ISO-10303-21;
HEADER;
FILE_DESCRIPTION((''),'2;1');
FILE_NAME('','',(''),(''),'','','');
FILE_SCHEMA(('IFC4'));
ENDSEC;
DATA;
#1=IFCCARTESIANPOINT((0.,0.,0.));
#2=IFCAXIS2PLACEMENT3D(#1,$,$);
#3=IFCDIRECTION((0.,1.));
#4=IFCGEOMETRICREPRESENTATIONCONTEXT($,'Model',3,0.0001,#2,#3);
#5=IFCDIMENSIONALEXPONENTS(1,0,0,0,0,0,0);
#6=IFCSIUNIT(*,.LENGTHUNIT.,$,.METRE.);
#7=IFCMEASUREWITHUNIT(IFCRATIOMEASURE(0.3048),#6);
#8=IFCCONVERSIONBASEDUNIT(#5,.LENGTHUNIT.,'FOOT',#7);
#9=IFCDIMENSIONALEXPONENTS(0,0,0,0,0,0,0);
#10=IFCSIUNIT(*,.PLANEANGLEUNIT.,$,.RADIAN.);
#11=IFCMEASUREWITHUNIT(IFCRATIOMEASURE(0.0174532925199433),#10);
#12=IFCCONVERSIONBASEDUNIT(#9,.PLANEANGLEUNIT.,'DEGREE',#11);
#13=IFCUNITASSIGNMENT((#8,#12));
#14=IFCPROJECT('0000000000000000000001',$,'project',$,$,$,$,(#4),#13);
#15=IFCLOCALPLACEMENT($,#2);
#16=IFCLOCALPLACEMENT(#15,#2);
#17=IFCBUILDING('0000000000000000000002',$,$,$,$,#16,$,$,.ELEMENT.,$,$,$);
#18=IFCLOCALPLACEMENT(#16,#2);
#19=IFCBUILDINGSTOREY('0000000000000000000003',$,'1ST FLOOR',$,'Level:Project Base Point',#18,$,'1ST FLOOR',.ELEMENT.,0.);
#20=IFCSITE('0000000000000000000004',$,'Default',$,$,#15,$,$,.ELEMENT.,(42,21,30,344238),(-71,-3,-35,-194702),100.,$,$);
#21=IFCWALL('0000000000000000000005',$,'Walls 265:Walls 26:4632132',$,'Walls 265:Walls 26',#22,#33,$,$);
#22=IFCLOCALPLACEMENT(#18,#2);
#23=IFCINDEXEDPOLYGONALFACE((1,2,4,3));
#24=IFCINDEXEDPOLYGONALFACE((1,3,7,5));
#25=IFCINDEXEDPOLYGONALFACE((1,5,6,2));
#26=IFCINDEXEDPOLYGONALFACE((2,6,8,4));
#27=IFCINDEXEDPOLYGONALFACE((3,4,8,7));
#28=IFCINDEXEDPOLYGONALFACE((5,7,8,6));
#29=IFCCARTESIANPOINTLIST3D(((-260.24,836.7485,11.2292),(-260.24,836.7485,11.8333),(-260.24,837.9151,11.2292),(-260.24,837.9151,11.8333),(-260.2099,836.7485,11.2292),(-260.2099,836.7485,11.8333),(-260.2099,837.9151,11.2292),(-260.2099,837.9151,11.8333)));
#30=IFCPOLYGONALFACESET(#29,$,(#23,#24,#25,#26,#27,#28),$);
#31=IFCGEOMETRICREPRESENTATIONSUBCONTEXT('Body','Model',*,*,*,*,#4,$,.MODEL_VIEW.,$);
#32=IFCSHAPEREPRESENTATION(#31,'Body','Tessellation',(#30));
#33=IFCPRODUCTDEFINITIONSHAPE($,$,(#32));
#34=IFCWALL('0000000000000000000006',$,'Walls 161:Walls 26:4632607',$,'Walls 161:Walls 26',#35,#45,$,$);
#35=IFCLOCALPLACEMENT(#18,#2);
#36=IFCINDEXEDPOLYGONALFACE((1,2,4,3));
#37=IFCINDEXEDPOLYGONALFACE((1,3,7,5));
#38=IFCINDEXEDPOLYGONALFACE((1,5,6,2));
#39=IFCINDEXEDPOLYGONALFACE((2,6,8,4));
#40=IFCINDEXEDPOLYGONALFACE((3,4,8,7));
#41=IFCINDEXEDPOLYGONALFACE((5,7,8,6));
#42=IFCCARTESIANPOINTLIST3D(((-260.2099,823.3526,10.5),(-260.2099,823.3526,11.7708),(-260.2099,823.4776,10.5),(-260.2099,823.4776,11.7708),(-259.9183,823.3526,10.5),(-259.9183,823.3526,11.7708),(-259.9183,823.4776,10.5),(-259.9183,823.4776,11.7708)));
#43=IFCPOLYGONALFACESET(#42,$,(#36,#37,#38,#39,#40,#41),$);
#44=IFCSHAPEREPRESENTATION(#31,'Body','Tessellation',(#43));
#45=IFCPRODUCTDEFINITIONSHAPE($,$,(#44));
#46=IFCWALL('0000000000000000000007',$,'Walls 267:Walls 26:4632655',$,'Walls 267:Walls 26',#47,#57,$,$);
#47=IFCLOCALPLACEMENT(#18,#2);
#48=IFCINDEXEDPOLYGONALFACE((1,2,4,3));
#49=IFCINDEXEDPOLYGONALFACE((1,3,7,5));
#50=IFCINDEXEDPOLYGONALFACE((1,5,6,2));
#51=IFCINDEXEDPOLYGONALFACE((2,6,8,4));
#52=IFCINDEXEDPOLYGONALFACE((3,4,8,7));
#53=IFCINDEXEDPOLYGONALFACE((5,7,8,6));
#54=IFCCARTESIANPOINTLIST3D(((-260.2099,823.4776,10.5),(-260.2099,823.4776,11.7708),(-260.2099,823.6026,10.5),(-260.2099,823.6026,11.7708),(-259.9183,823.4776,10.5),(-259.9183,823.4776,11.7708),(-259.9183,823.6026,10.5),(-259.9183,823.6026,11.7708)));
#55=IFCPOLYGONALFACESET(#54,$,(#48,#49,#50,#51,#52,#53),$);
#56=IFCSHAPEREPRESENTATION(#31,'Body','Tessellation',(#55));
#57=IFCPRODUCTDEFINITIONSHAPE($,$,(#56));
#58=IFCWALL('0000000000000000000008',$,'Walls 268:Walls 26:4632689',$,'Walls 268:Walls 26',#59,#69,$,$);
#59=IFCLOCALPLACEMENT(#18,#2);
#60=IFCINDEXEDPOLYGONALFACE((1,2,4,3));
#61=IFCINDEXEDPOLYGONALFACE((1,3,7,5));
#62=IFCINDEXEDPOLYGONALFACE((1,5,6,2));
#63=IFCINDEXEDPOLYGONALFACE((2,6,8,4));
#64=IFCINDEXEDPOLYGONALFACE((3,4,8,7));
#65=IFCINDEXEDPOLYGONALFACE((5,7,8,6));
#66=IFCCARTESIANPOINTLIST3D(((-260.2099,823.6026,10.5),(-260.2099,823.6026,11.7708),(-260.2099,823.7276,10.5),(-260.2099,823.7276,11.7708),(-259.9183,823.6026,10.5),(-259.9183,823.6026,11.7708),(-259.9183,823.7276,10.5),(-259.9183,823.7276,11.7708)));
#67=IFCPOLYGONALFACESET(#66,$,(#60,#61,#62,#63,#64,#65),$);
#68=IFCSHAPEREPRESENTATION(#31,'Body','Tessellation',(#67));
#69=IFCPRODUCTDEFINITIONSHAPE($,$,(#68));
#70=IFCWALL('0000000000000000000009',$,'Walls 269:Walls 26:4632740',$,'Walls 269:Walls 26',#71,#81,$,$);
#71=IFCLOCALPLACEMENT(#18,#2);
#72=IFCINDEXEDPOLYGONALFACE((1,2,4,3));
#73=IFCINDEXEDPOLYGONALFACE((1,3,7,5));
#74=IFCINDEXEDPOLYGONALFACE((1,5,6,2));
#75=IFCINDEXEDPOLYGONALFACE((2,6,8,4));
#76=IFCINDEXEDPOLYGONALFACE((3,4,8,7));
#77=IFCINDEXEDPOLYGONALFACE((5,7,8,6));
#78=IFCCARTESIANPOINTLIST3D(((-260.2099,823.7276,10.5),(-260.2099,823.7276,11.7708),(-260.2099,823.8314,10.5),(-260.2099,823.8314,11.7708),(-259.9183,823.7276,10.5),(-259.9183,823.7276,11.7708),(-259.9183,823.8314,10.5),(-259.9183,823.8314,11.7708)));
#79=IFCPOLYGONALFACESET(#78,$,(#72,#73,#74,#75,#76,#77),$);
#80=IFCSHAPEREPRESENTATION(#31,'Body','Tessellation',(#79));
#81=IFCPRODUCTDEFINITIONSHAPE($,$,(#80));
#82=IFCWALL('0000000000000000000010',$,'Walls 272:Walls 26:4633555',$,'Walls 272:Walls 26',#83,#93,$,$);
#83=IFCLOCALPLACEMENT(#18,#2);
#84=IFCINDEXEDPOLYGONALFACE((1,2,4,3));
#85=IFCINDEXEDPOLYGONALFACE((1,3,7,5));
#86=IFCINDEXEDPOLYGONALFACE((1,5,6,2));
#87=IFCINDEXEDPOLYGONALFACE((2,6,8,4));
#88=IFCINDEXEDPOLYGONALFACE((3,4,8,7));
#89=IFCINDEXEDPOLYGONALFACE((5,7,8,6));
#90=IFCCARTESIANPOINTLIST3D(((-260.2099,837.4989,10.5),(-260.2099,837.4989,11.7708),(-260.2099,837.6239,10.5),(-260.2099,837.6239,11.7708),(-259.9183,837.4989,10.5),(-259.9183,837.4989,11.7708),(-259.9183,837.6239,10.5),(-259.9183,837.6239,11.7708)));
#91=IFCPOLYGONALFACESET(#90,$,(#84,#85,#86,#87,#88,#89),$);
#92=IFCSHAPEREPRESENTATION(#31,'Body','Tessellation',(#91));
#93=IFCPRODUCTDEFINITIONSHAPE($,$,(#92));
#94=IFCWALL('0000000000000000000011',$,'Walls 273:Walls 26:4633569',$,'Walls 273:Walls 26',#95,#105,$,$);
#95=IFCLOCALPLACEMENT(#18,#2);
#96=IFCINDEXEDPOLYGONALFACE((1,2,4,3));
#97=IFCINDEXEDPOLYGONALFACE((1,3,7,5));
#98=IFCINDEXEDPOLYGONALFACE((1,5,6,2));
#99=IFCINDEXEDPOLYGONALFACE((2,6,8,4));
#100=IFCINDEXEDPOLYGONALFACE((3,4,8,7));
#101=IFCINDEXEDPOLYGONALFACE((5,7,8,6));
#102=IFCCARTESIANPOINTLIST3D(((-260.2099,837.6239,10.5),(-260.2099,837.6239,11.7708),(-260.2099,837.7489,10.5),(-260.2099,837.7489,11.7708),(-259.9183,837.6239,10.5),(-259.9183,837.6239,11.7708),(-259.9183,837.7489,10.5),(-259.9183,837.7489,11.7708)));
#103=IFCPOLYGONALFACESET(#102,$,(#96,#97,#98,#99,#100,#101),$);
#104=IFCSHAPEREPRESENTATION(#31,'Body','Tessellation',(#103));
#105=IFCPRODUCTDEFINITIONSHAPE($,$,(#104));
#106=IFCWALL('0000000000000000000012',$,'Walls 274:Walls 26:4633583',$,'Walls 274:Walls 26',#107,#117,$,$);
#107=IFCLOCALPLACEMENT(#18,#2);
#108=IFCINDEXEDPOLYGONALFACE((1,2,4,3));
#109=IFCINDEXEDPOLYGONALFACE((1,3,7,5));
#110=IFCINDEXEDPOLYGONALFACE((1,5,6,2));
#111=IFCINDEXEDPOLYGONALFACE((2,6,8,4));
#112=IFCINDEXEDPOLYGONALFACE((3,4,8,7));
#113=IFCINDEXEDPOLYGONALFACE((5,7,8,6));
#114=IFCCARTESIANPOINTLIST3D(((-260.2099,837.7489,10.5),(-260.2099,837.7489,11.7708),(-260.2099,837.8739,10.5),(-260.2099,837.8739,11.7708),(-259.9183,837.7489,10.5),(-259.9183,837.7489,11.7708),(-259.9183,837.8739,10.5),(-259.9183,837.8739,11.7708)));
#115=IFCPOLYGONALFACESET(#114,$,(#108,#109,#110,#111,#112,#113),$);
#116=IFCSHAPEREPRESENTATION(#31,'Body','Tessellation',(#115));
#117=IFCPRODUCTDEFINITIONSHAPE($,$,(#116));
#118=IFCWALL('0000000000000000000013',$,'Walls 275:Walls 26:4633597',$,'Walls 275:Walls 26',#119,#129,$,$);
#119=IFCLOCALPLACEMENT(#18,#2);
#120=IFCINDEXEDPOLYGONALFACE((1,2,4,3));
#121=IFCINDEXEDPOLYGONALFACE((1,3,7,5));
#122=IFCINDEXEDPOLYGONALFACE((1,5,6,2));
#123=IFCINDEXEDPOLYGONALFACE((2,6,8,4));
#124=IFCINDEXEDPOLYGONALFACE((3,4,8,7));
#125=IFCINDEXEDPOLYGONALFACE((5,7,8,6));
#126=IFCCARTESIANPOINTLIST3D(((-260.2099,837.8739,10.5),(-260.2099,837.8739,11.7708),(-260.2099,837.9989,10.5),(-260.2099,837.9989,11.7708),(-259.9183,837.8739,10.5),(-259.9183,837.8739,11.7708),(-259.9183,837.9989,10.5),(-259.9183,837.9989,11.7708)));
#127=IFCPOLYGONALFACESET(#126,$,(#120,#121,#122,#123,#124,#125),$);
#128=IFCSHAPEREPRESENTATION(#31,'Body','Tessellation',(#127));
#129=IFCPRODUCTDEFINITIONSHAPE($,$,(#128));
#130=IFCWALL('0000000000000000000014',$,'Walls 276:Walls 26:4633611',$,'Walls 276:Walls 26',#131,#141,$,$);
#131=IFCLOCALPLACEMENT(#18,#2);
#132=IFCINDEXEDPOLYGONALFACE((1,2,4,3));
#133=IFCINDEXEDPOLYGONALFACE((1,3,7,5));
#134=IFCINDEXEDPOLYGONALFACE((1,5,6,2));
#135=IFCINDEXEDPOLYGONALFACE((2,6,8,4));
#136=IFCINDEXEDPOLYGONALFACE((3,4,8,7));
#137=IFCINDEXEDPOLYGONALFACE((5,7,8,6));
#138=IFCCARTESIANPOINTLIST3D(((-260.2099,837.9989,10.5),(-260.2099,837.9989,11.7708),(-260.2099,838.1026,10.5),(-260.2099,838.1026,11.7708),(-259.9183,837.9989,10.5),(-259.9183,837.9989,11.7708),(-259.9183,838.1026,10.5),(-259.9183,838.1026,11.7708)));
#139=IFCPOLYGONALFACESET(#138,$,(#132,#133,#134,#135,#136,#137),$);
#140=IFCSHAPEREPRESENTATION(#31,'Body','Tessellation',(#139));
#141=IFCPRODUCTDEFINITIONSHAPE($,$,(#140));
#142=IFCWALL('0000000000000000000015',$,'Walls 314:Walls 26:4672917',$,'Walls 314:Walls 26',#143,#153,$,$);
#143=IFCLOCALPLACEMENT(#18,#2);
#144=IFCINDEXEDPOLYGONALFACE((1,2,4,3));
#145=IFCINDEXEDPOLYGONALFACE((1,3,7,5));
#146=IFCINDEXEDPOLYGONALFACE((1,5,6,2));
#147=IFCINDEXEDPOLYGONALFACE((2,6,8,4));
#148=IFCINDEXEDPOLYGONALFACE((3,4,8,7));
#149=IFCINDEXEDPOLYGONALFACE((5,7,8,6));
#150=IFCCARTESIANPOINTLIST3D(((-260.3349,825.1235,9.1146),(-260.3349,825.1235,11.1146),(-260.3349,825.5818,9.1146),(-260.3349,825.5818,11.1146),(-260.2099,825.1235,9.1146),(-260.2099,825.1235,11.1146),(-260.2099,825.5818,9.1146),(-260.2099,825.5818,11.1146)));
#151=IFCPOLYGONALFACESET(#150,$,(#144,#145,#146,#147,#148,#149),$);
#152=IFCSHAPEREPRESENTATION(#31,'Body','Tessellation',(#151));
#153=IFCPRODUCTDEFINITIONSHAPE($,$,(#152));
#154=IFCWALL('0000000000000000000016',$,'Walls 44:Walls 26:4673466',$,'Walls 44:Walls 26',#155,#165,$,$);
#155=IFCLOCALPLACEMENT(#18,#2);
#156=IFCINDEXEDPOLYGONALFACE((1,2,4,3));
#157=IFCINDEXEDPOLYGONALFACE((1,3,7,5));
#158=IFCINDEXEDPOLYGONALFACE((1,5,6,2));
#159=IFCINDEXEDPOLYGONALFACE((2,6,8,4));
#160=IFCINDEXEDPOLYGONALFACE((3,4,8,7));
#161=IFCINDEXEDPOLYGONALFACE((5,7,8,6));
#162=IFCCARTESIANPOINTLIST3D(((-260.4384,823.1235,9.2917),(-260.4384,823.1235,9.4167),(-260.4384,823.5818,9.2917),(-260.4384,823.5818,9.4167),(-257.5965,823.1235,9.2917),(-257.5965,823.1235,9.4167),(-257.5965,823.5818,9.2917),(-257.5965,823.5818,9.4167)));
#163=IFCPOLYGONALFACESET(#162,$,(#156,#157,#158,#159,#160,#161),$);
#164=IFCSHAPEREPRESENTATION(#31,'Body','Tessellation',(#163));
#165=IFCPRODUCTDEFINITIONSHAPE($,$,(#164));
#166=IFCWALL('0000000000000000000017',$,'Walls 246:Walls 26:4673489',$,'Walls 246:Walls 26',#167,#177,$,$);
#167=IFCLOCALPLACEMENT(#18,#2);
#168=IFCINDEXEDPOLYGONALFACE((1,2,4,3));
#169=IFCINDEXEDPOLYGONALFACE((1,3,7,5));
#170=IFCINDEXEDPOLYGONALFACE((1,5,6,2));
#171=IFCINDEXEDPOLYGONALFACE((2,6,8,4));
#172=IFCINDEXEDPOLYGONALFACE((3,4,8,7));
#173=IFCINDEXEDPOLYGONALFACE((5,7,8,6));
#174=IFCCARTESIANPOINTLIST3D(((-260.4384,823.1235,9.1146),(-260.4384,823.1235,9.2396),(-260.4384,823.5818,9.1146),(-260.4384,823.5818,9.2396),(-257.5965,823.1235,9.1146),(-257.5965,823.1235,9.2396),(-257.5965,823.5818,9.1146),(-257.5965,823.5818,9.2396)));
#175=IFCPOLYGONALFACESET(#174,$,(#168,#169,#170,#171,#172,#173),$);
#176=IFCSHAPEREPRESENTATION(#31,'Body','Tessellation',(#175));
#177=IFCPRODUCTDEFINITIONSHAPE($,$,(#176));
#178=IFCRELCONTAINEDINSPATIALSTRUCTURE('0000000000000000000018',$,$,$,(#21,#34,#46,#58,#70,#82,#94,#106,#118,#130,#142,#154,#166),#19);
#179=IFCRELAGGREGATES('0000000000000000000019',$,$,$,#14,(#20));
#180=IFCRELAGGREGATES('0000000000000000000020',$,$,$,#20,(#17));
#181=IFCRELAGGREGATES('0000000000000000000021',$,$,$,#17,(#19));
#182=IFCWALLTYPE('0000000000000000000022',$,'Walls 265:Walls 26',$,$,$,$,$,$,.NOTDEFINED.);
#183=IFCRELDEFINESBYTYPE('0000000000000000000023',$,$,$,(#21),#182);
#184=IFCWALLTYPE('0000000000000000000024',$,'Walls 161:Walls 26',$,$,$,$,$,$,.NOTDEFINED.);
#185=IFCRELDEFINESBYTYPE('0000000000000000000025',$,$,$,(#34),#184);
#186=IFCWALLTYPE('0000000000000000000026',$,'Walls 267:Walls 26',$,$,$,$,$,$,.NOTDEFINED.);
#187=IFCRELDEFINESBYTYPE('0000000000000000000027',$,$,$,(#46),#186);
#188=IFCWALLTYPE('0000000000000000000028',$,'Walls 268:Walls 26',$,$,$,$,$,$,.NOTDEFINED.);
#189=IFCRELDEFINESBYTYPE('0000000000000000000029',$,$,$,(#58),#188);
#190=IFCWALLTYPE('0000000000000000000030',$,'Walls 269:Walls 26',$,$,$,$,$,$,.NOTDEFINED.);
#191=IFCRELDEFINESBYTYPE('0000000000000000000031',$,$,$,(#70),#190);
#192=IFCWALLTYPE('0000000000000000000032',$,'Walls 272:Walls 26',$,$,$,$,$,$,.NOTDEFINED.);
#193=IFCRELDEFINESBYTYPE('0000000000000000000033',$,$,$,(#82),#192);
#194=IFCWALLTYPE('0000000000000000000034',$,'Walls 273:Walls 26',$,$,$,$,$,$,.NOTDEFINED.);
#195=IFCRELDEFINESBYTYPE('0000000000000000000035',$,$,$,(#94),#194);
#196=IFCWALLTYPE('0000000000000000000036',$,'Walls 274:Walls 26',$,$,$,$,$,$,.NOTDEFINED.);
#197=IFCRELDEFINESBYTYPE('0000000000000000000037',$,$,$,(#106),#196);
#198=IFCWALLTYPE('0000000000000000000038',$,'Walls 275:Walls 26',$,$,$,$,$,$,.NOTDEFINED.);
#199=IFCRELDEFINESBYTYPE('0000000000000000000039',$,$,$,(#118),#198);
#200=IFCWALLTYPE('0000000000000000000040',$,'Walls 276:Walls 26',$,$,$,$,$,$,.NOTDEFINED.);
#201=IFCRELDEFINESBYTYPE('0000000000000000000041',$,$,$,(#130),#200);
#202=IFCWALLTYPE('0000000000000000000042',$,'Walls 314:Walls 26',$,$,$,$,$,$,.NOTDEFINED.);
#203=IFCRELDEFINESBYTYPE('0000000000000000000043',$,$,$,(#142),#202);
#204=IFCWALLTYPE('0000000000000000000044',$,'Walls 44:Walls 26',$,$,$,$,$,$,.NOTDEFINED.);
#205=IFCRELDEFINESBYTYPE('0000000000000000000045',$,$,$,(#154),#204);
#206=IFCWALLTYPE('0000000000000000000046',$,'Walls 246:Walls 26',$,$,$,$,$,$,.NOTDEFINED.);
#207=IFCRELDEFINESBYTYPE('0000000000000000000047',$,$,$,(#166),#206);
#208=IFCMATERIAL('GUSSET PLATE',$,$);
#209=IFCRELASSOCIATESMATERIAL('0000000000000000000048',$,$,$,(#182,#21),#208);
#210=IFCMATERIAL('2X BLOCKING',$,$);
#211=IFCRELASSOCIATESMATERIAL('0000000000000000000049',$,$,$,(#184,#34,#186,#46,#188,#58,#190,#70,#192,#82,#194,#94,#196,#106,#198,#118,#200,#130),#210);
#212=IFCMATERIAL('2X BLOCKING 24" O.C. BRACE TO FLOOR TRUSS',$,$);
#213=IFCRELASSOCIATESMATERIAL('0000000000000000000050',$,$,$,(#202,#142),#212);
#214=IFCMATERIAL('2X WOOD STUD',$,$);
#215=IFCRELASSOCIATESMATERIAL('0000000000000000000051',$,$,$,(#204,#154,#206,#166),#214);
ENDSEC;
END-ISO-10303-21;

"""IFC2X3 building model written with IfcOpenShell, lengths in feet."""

from ifc_helpers import new_model, entity, si_unit, converted_unit, direction, frame, frame_2d, origin, place, context, subcontext, project, spatial, rectangle, extrude, material, type_object, element, save


model = new_model("IFC2X3")

# Units and contexts
model_context = context("Model", 3, precision=0.0001, world=origin(), true_north=direction((0.0, 1.0)))
body_context = subcontext(model_context, "Body", "Model", "MODEL_VIEW")
ifc_project = project(units=[converted_unit("LENGTHUNIT", "FOOT", entity("IfcRatioMeasure", 0.3048), si_unit("LENGTHUNIT", "METRE"), dimensions=[1, 0, 0, 0, 0, 0, 0]), converted_unit("PLANEANGLEUNIT", "DEGREE", entity("IfcRatioMeasure", 0.0174532925199433), si_unit("PLANEANGLEUNIT", "RADIAN"), dimensions=[0, 0, 0, 0, 0, 0, 0])], contexts=[model_context])

# Site, building, storey
site_placement = place(None, origin())
site = spatial("IfcSite", under=ifc_project, at=site_placement, Name="Default", CompositionType="ELEMENT", RefLatitude=(42, 21, 30, 344238), RefLongitude=(-71, -3, -35, -194702), RefElevation=100.0)
building_placement = place(site_placement, origin())
building = spatial("IfcBuilding", under=site, at=building_placement, CompositionType="ELEMENT")
storey_placement = place(building_placement, origin())
storey = spatial("IfcBuildingStorey", under=building, at=storey_placement, Name="1ST FLOOR", ObjectType="Level:Project Base Point", LongName="1ST FLOOR", CompositionType="ELEMENT", Elevation=0.0)

# Walls
ifc_material_1 = material(Name="GUSSET PLATE")
ifc_material_2 = material(Name="2X BLOCKING")
wall_type_1 = type_object("IfcWallType", Name="Walls 265:Walls 26", PredefinedType="NOTDEFINED", material=ifc_material_1)
wall_1_placement = place(storey_placement, frame((-260.24, 836.7485, 11.2292), z_axis=(0.0, 0.0, 1.0), x_axis=(0.0, 1.0, 0.0)))
element("IfcWall", 1, at=wall_1_placement, inside=storey, type_object=wall_type_1, material=ifc_material_1, Name="Walls 265:Walls 26:4632132", ObjectType="Walls 265:Walls 26", context=body_context, shape_type="SweptSolid", body=[
    extrude(rectangle(XDim=0.0301, YDim=1.1667, at=frame_2d((0.0, 0.0), x_axis=(1.0, 0.0))), frame((0.5833, -0.0151, 0.0), z_axis=(0.0, 0.0, 1.0), x_axis=(0.0, 1.0, 0.0)), (0.0, 0.0, 1.0), 0.6042),
])
wall_type_2 = type_object("IfcWallType", Name="Walls 161:Walls 26", PredefinedType="NOTDEFINED", material=ifc_material_2)
wall_2_placement = place(storey_placement, frame((-260.2099, 823.3526, 10.5)))
element("IfcWall", 2, at=wall_2_placement, inside=storey, type_object=wall_type_2, material=ifc_material_2, Name="Walls 161:Walls 26:4632607", ObjectType="Walls 161:Walls 26", context=body_context, shape_type="SweptSolid", body=[
    extrude(rectangle(XDim=0.2917, YDim=0.125, at=frame_2d((0.0, 0.0), x_axis=(1.0, 0.0))), frame((0.1458, 0.0625, 0.0), z_axis=(0.0, 0.0, 1.0), x_axis=(-1.0, 0.0, 0.0)), (0.0, 0.0, 1.0), 1.2708),
])
wall_type_3 = type_object("IfcWallType", Name="Walls 267:Walls 26", PredefinedType="NOTDEFINED", material=ifc_material_2)
wall_3_placement = place(storey_placement, frame((-260.2099, 823.4776, 10.5)))
element("IfcWall", 3, at=wall_3_placement, inside=storey, type_object=wall_type_3, material=ifc_material_2, Name="Walls 267:Walls 26:4632655", ObjectType="Walls 267:Walls 26", context=body_context, shape_type="SweptSolid", body=[
    extrude(rectangle(XDim=0.2917, YDim=0.125, at=frame_2d((0.0, 0.0), x_axis=(1.0, 0.0))), frame((0.1458, 0.0625, 0.0), z_axis=(0.0, 0.0, 1.0), x_axis=(-1.0, 0.0, 0.0)), (0.0, 0.0, 1.0), 1.2708),
])
wall_type_4 = type_object("IfcWallType", Name="Walls 268:Walls 26", PredefinedType="NOTDEFINED", material=ifc_material_2)
wall_4_placement = place(storey_placement, frame((-260.2099, 823.6026, 10.5)))
element("IfcWall", 4, at=wall_4_placement, inside=storey, type_object=wall_type_4, material=ifc_material_2, Name="Walls 268:Walls 26:4632689", ObjectType="Walls 268:Walls 26", context=body_context, shape_type="SweptSolid", body=[
    extrude(rectangle(XDim=0.2917, YDim=0.125, at=frame_2d((0.0, 0.0), x_axis=(1.0, 0.0))), frame((0.1458, 0.0625, 0.0), z_axis=(0.0, 0.0, 1.0), x_axis=(-1.0, 0.0, 0.0)), (0.0, 0.0, 1.0), 1.2708),
])
wall_type_5 = type_object("IfcWallType", Name="Walls 269:Walls 26", PredefinedType="NOTDEFINED", material=ifc_material_2)
wall_5_placement = place(storey_placement, frame((-260.2099, 823.7276, 10.5)))
element("IfcWall", 5, at=wall_5_placement, inside=storey, type_object=wall_type_5, material=ifc_material_2, Name="Walls 269:Walls 26:4632740", ObjectType="Walls 269:Walls 26", context=body_context, shape_type="SweptSolid", body=[
    extrude(rectangle(XDim=0.2917, YDim=0.1038, at=frame_2d((0.0, 0.0), x_axis=(1.0, 0.0))), frame((0.1458, 0.0519, 0.0), z_axis=(0.0, 0.0, 1.0), x_axis=(-1.0, 0.0, 0.0)), (0.0, 0.0, 1.0), 1.2708),
])
wall_type_6 = type_object("IfcWallType", Name="Walls 272:Walls 26", PredefinedType="NOTDEFINED", material=ifc_material_2)
wall_6_placement = place(storey_placement, frame((-260.2099, 837.4989, 10.5)))
element("IfcWall", 6, at=wall_6_placement, inside=storey, type_object=wall_type_6, material=ifc_material_2, Name="Walls 272:Walls 26:4633555", ObjectType="Walls 272:Walls 26", context=body_context, shape_type="SweptSolid", body=[
    extrude(rectangle(XDim=0.2917, YDim=0.125, at=frame_2d((0.0, 0.0), x_axis=(1.0, 0.0))), frame((0.1458, 0.0625, 0.0), z_axis=(0.0, 0.0, 1.0), x_axis=(-1.0, 0.0, 0.0)), (0.0, 0.0, 1.0), 1.2708),
])
wall_type_7 = type_object("IfcWallType", Name="Walls 273:Walls 26", PredefinedType="NOTDEFINED", material=ifc_material_2)
wall_7_placement = place(storey_placement, frame((-260.2099, 837.6239, 10.5)))
element("IfcWall", 7, at=wall_7_placement, inside=storey, type_object=wall_type_7, material=ifc_material_2, Name="Walls 273:Walls 26:4633569", ObjectType="Walls 273:Walls 26", context=body_context, shape_type="SweptSolid", body=[
    extrude(rectangle(XDim=0.2917, YDim=0.125, at=frame_2d((0.0, 0.0), x_axis=(1.0, 0.0))), frame((0.1458, 0.0625, 0.0), z_axis=(0.0, 0.0, 1.0), x_axis=(-1.0, 0.0, 0.0)), (0.0, 0.0, 1.0), 1.2708),
])
wall_type_8 = type_object("IfcWallType", Name="Walls 274:Walls 26", PredefinedType="NOTDEFINED", material=ifc_material_2)
wall_8_placement = place(storey_placement, frame((-260.2099, 837.7489, 10.5)))
element("IfcWall", 8, at=wall_8_placement, inside=storey, type_object=wall_type_8, material=ifc_material_2, Name="Walls 274:Walls 26:4633583", ObjectType="Walls 274:Walls 26", context=body_context, shape_type="SweptSolid", body=[
    extrude(rectangle(XDim=0.2917, YDim=0.125, at=frame_2d((0.0, 0.0), x_axis=(1.0, 0.0))), frame((0.1458, 0.0625, 0.0), z_axis=(0.0, 0.0, 1.0), x_axis=(-1.0, 0.0, 0.0)), (0.0, 0.0, 1.0), 1.2708),
])
wall_type_9 = type_object("IfcWallType", Name="Walls 275:Walls 26", PredefinedType="NOTDEFINED", material=ifc_material_2)
wall_9_placement = place(storey_placement, frame((-260.2099, 837.8739, 10.5)))
element("IfcWall", 9, at=wall_9_placement, inside=storey, type_object=wall_type_9, material=ifc_material_2, Name="Walls 275:Walls 26:4633597", ObjectType="Walls 275:Walls 26", context=body_context, shape_type="SweptSolid", body=[
    extrude(rectangle(XDim=0.2917, YDim=0.125, at=frame_2d((0.0, 0.0), x_axis=(1.0, 0.0))), frame((0.1458, 0.0625, 0.0), z_axis=(0.0, 0.0, 1.0), x_axis=(-1.0, 0.0, 0.0)), (0.0, 0.0, 1.0), 1.2708),
])
wall_type_10 = type_object("IfcWallType", Name="Walls 276:Walls 26", PredefinedType="NOTDEFINED", material=ifc_material_2)
wall_10_placement = place(storey_placement, frame((-260.2099, 837.9989, 10.5)))
element("IfcWall", 10, at=wall_10_placement, inside=storey, type_object=wall_type_10, material=ifc_material_2, Name="Walls 276:Walls 26:4633611", ObjectType="Walls 276:Walls 26", context=body_context, shape_type="SweptSolid", body=[
    extrude(rectangle(XDim=0.2917, YDim=0.1038, at=frame_2d((0.0, 0.0), x_axis=(1.0, 0.0))), frame((0.1458, 0.0519, 0.0), z_axis=(0.0, 0.0, 1.0), x_axis=(-1.0, 0.0, 0.0)), (0.0, 0.0, 1.0), 1.2708),
])
ifc_material_3 = material(Name="2X BLOCKING 24\" O.C. BRACE TO FLOOR TRUSS")
wall_type_11 = type_object("IfcWallType", Name="Walls 314:Walls 26", PredefinedType="NOTDEFINED", material=ifc_material_3)
wall_11_placement = place(storey_placement, frame((-260.3349, 825.1235, 9.1146), z_axis=(0.0, 0.0, 1.0), x_axis=(0.0, 1.0, 0.0)))
element("IfcWall", 11, at=wall_11_placement, inside=storey, type_object=wall_type_11, material=ifc_material_3, Name="Walls 314:Walls 26:4672917", ObjectType="Walls 314:Walls 26", context=body_context, shape_type="SweptSolid", body=[
    extrude(rectangle(XDim=0.4583, YDim=0.125, at=frame_2d((0.0, 0.0), x_axis=(1.0, 0.0))), frame((0.2292, -0.0625, 0.0)), (0.0, 0.0, 1.0), 2.0),
])
ifc_material_4 = material(Name="2X WOOD STUD")
wall_type_12 = type_object("IfcWallType", Name="Walls 44:Walls 26", PredefinedType="NOTDEFINED", material=ifc_material_4)
wall_12_placement = place(storey_placement, frame((-260.4384, 823.1235, 9.2917)))
element("IfcWall", 12, at=wall_12_placement, inside=storey, type_object=wall_type_12, material=ifc_material_4, Name="Walls 44:Walls 26:4673466", ObjectType="Walls 44:Walls 26", context=body_context, shape_type="SweptSolid", body=[
    extrude(rectangle(XDim=2.8419, YDim=0.4583, at=frame_2d((0.0, 0.0), x_axis=(1.0, 0.0))), frame((1.421, 0.2292, 0.0), z_axis=(0.0, 0.0, 1.0), x_axis=(-1.0, 0.0, 0.0)), (0.0, 0.0, 1.0), 0.125),
])
wall_type_13 = type_object("IfcWallType", Name="Walls 246:Walls 26", PredefinedType="NOTDEFINED", material=ifc_material_4)
wall_13_placement = place(storey_placement, frame((-260.4384, 823.1235, 9.1146)))
element("IfcWall", 13, at=wall_13_placement, inside=storey, type_object=wall_type_13, material=ifc_material_4, Name="Walls 246:Walls 26:4673489", ObjectType="Walls 246:Walls 26", context=body_context, shape_type="SweptSolid", body=[
    extrude(rectangle(XDim=2.8419, YDim=0.4583, at=frame_2d((0.0, 0.0), x_axis=(1.0, 0.0))), frame((1.421, 0.2292, 0.0), z_axis=(0.0, 0.0, 1.0), x_axis=(-1.0, 0.0, 0.0)), (0.0, 0.0, 1.0), 0.125),
])

save(model, "model.ifc")
